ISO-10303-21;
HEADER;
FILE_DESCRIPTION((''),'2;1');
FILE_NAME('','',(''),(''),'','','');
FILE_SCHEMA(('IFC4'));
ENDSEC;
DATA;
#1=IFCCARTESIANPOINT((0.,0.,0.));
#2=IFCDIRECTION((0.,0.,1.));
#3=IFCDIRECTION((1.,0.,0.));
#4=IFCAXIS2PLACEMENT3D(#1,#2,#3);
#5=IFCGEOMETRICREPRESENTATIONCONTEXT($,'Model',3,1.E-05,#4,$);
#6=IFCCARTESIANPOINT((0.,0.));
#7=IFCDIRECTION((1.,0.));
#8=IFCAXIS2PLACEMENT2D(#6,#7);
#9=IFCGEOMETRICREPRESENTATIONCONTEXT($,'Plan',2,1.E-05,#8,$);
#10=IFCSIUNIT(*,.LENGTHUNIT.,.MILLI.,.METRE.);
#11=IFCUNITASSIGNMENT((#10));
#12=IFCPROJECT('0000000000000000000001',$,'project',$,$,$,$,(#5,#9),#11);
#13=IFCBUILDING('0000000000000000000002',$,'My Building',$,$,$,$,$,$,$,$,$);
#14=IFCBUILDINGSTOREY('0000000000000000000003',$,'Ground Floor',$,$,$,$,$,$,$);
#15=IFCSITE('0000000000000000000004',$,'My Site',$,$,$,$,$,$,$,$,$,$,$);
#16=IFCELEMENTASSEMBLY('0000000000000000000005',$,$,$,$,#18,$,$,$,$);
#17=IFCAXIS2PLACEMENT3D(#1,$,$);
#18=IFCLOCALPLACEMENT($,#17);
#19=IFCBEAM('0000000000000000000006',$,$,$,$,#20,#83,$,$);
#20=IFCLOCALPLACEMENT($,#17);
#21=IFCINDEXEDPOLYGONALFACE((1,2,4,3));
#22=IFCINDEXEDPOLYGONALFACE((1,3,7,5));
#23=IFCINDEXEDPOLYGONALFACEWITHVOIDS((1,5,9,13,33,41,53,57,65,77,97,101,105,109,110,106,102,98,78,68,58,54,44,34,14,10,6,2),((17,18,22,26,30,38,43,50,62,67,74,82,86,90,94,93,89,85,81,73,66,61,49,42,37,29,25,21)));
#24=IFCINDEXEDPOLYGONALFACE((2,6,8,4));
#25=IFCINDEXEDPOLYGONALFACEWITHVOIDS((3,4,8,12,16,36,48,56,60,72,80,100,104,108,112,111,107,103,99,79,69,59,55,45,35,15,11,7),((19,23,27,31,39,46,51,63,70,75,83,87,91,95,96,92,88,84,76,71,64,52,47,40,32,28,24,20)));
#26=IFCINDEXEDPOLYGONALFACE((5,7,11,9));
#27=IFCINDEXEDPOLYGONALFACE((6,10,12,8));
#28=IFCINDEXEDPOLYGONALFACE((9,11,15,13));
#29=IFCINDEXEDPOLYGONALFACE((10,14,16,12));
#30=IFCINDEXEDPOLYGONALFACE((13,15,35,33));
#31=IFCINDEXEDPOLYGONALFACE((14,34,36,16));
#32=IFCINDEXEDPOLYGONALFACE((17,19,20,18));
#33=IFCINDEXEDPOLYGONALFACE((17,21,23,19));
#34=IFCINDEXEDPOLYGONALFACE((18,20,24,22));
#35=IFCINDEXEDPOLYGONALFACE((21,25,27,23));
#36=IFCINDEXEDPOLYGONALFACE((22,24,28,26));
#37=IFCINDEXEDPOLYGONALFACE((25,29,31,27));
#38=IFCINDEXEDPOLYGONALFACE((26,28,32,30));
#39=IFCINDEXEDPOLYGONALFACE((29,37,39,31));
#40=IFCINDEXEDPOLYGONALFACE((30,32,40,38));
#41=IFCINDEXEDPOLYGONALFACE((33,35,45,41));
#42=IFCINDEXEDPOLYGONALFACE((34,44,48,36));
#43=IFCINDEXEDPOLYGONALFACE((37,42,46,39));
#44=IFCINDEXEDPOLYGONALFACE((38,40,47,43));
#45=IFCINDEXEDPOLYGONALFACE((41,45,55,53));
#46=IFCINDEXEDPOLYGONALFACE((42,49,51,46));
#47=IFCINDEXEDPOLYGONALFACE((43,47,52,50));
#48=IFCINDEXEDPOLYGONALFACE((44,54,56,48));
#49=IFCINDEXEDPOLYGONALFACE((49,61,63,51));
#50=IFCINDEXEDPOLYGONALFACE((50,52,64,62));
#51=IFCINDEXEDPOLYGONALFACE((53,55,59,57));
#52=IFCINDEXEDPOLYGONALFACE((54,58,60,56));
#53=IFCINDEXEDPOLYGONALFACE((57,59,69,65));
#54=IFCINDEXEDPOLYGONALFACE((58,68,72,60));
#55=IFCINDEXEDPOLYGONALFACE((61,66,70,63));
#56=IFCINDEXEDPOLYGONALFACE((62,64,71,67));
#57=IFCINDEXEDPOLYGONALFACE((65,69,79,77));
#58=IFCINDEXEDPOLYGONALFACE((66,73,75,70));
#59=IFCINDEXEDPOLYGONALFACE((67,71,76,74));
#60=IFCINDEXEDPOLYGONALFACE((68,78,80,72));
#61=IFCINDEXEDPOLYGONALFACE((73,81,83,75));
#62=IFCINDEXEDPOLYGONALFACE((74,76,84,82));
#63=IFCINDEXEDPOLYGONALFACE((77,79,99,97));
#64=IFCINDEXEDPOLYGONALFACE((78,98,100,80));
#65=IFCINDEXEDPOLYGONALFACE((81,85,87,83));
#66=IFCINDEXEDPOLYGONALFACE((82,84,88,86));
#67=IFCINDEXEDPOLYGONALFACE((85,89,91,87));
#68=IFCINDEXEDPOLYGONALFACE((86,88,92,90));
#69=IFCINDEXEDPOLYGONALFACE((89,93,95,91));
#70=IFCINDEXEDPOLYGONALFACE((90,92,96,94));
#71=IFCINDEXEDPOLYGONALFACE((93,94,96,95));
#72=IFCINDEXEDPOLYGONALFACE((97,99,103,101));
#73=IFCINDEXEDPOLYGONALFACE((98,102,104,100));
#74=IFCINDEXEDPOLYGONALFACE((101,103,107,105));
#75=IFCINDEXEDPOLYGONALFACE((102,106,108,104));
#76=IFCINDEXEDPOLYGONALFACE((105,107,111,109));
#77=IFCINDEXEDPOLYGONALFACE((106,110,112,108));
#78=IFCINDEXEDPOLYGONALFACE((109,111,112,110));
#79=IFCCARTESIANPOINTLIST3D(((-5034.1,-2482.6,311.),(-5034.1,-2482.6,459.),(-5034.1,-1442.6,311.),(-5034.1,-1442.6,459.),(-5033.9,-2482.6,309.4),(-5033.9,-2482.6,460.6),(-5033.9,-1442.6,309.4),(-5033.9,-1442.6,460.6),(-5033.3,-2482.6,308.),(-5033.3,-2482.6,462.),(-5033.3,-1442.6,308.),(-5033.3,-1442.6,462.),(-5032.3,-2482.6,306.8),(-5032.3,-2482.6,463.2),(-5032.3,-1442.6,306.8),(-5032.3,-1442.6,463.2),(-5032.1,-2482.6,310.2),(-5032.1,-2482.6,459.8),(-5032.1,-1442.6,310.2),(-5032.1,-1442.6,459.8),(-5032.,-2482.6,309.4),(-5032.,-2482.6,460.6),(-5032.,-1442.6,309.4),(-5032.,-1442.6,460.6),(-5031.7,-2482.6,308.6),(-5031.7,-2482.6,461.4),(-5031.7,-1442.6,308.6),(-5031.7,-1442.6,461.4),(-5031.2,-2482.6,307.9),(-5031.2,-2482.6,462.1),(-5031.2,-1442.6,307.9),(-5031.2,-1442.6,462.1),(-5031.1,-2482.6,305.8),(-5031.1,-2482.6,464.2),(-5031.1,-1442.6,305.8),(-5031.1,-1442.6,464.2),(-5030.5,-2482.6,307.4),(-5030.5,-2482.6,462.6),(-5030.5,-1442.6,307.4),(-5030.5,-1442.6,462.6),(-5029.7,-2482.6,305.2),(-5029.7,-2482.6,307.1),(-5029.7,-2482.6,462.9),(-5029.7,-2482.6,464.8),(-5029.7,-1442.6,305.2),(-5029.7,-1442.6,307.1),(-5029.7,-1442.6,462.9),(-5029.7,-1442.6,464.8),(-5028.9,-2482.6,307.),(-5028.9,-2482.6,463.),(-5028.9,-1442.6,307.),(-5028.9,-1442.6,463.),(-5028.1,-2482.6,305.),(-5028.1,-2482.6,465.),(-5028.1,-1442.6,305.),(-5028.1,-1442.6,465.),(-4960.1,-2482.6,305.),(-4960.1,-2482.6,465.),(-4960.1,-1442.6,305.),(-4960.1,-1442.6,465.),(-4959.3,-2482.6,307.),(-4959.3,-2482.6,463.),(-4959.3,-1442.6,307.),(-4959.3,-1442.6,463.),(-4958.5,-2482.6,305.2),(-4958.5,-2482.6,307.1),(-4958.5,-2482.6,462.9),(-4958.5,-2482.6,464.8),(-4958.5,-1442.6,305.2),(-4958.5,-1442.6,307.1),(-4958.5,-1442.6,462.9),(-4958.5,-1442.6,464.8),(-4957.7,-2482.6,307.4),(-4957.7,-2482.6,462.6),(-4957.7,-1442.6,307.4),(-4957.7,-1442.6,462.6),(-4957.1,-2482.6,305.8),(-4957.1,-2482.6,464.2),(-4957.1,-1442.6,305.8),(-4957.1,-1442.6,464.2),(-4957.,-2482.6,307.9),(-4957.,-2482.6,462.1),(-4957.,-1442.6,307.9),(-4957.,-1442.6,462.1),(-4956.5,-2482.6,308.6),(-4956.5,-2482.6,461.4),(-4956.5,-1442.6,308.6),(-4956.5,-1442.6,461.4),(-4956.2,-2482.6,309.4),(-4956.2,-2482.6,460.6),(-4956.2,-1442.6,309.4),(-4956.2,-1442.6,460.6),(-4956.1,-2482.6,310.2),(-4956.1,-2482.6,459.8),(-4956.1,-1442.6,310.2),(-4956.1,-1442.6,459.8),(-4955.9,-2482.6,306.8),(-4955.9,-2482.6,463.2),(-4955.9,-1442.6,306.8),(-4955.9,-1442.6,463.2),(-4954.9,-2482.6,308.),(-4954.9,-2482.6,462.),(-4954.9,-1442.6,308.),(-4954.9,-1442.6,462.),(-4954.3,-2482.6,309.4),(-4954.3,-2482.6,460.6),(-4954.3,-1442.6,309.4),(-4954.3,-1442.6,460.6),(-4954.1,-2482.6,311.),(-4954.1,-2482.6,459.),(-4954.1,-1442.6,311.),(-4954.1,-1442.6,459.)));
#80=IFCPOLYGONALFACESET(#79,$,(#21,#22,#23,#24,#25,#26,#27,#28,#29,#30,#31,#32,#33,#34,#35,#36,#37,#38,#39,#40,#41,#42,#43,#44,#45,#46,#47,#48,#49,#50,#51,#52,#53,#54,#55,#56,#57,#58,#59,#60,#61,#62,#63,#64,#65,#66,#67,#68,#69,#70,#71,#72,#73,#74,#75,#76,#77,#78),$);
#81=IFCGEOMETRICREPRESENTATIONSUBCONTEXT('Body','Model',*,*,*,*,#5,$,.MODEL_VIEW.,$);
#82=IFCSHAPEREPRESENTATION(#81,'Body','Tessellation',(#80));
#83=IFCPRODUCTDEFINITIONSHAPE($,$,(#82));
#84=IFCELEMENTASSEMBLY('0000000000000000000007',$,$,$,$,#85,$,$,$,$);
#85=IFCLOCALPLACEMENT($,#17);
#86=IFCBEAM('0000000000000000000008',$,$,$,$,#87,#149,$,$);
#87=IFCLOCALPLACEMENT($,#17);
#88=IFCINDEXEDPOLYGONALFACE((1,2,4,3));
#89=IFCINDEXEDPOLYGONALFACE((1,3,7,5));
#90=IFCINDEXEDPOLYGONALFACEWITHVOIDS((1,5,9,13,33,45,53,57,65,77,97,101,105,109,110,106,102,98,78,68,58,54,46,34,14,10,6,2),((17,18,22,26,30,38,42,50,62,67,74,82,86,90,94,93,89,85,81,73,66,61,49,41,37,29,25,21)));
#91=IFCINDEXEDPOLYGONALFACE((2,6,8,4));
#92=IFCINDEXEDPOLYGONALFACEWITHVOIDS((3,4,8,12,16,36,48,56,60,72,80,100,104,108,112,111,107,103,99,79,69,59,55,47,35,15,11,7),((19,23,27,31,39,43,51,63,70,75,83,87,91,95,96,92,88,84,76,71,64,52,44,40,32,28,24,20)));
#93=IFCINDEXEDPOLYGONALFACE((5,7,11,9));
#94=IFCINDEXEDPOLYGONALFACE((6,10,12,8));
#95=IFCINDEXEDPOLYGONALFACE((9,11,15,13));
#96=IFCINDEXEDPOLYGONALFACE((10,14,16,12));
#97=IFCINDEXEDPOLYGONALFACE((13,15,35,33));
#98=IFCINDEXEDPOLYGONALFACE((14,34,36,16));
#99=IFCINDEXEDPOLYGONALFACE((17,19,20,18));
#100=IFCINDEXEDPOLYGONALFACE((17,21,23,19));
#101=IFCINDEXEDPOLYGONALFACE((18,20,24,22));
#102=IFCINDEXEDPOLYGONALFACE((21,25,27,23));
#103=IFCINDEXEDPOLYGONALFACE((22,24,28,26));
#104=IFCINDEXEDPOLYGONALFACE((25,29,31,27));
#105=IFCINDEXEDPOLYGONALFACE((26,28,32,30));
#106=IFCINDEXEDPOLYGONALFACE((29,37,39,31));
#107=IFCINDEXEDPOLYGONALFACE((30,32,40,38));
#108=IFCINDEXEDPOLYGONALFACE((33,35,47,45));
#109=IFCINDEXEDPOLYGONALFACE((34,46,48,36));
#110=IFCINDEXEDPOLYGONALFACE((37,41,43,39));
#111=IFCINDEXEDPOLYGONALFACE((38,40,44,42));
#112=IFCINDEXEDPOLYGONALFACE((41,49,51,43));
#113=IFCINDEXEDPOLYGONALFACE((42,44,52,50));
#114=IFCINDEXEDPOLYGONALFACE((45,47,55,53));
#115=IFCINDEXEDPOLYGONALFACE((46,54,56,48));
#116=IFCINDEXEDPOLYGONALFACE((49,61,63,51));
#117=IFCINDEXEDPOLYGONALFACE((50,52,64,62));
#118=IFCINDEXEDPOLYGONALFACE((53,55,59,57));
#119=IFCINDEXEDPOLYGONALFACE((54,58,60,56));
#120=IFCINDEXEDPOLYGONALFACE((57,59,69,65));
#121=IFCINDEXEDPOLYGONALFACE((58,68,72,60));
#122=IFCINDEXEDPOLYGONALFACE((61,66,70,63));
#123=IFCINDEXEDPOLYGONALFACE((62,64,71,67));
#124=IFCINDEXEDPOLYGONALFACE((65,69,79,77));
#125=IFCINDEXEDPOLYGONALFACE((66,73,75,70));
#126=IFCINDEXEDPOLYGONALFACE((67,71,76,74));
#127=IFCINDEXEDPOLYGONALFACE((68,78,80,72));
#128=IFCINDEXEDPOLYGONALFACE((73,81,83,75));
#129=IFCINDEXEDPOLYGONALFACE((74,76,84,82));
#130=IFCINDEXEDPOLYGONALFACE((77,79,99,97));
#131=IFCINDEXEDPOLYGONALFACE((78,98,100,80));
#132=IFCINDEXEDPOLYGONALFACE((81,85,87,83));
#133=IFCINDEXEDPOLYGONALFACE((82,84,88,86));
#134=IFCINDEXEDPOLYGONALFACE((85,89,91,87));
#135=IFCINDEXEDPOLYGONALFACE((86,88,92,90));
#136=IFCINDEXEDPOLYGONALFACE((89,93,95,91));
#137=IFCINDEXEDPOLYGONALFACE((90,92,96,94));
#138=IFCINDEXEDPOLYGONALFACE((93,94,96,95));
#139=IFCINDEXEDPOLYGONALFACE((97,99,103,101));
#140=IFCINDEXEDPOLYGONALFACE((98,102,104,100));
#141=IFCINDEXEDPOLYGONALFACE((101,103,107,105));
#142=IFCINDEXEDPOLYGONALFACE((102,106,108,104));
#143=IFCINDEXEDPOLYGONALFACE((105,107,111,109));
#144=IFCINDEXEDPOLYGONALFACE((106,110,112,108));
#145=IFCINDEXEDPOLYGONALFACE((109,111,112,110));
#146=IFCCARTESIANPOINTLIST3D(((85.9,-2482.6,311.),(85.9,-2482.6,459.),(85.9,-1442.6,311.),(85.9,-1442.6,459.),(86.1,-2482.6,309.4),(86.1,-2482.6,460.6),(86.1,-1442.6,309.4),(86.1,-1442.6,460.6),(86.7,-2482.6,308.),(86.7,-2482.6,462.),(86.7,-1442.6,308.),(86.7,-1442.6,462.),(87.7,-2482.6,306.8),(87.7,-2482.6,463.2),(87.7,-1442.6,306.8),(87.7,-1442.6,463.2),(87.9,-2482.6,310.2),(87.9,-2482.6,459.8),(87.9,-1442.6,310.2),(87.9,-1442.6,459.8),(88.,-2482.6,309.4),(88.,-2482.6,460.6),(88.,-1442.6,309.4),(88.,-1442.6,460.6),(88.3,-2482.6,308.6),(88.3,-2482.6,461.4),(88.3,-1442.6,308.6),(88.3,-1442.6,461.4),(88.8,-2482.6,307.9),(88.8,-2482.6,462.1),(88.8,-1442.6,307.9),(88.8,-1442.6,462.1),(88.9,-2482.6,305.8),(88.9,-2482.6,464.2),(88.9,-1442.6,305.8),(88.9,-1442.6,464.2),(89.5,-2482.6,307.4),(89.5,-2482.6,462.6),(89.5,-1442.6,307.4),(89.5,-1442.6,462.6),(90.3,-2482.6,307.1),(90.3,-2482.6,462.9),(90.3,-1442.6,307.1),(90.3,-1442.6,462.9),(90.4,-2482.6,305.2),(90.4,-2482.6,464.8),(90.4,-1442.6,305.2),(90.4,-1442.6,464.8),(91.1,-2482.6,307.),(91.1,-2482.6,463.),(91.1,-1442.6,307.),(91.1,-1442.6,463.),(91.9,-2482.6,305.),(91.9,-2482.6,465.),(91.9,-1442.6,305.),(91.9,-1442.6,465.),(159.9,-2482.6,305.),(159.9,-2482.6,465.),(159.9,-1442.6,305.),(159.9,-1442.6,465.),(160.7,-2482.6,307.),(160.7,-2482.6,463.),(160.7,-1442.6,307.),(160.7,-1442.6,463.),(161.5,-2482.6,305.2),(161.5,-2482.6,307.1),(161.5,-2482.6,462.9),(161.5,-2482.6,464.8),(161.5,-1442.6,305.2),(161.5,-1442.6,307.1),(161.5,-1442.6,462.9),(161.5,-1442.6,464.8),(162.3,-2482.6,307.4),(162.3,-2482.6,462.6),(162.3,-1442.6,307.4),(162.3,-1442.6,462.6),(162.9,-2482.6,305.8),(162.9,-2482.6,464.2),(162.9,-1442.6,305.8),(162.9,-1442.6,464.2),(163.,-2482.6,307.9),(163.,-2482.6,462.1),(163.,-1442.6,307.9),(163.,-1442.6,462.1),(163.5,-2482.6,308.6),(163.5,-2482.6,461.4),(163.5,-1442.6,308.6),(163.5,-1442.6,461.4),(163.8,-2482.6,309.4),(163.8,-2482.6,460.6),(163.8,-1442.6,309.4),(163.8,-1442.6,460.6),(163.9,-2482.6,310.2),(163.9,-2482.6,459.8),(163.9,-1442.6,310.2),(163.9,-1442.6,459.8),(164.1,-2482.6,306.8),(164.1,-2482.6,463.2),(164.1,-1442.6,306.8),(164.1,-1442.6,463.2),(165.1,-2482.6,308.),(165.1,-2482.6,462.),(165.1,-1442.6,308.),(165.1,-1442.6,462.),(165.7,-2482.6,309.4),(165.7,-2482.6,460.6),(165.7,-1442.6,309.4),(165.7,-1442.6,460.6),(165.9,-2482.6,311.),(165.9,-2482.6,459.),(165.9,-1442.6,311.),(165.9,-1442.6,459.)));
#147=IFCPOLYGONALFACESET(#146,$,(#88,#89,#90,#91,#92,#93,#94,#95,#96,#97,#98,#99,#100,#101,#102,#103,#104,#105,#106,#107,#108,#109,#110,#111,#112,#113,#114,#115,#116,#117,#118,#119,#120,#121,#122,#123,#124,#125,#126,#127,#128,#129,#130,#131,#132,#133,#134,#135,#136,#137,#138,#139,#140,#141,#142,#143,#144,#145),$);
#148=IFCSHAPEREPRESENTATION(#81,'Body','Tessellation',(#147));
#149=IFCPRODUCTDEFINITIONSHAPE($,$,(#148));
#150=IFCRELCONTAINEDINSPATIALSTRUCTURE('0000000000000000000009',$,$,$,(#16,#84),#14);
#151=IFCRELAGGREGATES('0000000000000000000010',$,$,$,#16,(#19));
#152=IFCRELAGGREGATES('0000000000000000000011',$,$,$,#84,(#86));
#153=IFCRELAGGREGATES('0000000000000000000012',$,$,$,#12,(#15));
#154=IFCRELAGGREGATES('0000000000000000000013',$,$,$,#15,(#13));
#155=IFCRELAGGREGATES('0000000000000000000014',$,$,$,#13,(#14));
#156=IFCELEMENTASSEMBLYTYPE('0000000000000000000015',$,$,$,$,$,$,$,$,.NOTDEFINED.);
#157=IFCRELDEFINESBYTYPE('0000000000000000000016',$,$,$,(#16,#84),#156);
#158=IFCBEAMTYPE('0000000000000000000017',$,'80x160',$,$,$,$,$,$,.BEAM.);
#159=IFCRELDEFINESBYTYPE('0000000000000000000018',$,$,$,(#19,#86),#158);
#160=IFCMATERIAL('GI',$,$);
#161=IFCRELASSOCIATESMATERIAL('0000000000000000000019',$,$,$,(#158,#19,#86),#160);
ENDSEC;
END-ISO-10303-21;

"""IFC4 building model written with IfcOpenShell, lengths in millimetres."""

from ifc_helpers import new_model, si_unit, frame, origin_with_axes, origin_2d_with_axis, place, context, subcontext, project, spatial, hollow_rectangle, extrude, material, material_profile, profile_set, profile_usage, type_object, element, aggregate, save


model = new_model("IFC4")

# Units and contexts
model_context = context("Model", 3, precision=1e-05, world=origin_with_axes())
plan_context = context("Plan", 2, precision=1e-05, world=origin_2d_with_axis())
body_context = subcontext(model_context, "Body", "Model", "MODEL_VIEW")
ifc_project = project(units=[si_unit("LENGTHUNIT", "METRE", prefix="MILLI")], contexts=[model_context, plan_context])

# Site, building, storey
site = spatial("IfcSite", under=ifc_project, Name="My Site")
building = spatial("IfcBuilding", under=site, Name="My Building")
storey = spatial("IfcBuildingStorey", under=building, Name="Ground Floor")

# Shared definitions
ifc_material_1 = material(Name="GI")

# Element assemblies, beams
element_assembly_type_1 = type_object("IfcElementAssemblyType", PredefinedType="NOTDEFINED")
ifc_material_profile_1 = material_profile(ifc_material_1, hollow_rectangle(XDim=80.0, YDim=160.0, WallThickness=2.0, InnerFilletRadius=3.2, OuterFilletRadius=6.0))
ifc_profile_set_1 = profile_set([ifc_material_profile_1], Name="80x160 GI Rectangular Hollow")
beam_type = type_object("IfcBeamType", Name="80x160", PredefinedType="BEAM", material=ifc_profile_set_1)
assembly_1_placement = place(None, frame((-4994.1, -2562.6, 385.0), z_axis=(0.0, 1.0, 0.0), x_axis=(1.0, 0.0, 0.0)))
assembly_1 = element("IfcElementAssembly", 1, at=assembly_1_placement, inside=storey, type_object=element_assembly_type_1)
ifc_profile_usage_1 = profile_usage(ifc_profile_set_1)
beam_1_placement = place(assembly_1_placement, frame((0.0, 0.0, 80.0), z_axis=(0.0, 0.0, 1.0), x_axis=(1.0, 0.0, 0.0)))
beam_1 = element("IfcBeam", 2, at=beam_1_placement, type_object=beam_type, material=ifc_profile_usage_1, context=body_context, shape_type="SweptSolid", body=[
    extrude(hollow_rectangle(XDim=80.0, YDim=160.0, WallThickness=2.0, InnerFilletRadius=3.2, OuterFilletRadius=6.0), origin_with_axes(), (0.0, 0.0, 1.0), 1040.0),
])
aggregate(assembly_1, [beam_1])
assembly_2_placement = place(None, frame((125.9, -2562.6, 385.0), z_axis=(0.0, 1.0, 0.0), x_axis=(1.0, 0.0, 0.0)))
assembly_2 = element("IfcElementAssembly", 3, at=assembly_2_placement, inside=storey, type_object=element_assembly_type_1)
ifc_profile_usage_2 = profile_usage(ifc_profile_set_1)
beam_2_placement = place(assembly_2_placement, frame((0.0, 0.0, 80.0), z_axis=(0.0, 0.0, 1.0), x_axis=(1.0, 0.0, 0.0)))
beam_2 = element("IfcBeam", 4, at=beam_2_placement, type_object=beam_type, material=ifc_profile_usage_2, context=body_context, shape_type="SweptSolid", body=[
    extrude(hollow_rectangle(XDim=80.0, YDim=160.0, WallThickness=2.0, InnerFilletRadius=3.2, OuterFilletRadius=6.0), origin_with_axes(), (0.0, 0.0, 1.0), 1040.0),
])
aggregate(assembly_2, [beam_2])

save(model, "model.ifc")
